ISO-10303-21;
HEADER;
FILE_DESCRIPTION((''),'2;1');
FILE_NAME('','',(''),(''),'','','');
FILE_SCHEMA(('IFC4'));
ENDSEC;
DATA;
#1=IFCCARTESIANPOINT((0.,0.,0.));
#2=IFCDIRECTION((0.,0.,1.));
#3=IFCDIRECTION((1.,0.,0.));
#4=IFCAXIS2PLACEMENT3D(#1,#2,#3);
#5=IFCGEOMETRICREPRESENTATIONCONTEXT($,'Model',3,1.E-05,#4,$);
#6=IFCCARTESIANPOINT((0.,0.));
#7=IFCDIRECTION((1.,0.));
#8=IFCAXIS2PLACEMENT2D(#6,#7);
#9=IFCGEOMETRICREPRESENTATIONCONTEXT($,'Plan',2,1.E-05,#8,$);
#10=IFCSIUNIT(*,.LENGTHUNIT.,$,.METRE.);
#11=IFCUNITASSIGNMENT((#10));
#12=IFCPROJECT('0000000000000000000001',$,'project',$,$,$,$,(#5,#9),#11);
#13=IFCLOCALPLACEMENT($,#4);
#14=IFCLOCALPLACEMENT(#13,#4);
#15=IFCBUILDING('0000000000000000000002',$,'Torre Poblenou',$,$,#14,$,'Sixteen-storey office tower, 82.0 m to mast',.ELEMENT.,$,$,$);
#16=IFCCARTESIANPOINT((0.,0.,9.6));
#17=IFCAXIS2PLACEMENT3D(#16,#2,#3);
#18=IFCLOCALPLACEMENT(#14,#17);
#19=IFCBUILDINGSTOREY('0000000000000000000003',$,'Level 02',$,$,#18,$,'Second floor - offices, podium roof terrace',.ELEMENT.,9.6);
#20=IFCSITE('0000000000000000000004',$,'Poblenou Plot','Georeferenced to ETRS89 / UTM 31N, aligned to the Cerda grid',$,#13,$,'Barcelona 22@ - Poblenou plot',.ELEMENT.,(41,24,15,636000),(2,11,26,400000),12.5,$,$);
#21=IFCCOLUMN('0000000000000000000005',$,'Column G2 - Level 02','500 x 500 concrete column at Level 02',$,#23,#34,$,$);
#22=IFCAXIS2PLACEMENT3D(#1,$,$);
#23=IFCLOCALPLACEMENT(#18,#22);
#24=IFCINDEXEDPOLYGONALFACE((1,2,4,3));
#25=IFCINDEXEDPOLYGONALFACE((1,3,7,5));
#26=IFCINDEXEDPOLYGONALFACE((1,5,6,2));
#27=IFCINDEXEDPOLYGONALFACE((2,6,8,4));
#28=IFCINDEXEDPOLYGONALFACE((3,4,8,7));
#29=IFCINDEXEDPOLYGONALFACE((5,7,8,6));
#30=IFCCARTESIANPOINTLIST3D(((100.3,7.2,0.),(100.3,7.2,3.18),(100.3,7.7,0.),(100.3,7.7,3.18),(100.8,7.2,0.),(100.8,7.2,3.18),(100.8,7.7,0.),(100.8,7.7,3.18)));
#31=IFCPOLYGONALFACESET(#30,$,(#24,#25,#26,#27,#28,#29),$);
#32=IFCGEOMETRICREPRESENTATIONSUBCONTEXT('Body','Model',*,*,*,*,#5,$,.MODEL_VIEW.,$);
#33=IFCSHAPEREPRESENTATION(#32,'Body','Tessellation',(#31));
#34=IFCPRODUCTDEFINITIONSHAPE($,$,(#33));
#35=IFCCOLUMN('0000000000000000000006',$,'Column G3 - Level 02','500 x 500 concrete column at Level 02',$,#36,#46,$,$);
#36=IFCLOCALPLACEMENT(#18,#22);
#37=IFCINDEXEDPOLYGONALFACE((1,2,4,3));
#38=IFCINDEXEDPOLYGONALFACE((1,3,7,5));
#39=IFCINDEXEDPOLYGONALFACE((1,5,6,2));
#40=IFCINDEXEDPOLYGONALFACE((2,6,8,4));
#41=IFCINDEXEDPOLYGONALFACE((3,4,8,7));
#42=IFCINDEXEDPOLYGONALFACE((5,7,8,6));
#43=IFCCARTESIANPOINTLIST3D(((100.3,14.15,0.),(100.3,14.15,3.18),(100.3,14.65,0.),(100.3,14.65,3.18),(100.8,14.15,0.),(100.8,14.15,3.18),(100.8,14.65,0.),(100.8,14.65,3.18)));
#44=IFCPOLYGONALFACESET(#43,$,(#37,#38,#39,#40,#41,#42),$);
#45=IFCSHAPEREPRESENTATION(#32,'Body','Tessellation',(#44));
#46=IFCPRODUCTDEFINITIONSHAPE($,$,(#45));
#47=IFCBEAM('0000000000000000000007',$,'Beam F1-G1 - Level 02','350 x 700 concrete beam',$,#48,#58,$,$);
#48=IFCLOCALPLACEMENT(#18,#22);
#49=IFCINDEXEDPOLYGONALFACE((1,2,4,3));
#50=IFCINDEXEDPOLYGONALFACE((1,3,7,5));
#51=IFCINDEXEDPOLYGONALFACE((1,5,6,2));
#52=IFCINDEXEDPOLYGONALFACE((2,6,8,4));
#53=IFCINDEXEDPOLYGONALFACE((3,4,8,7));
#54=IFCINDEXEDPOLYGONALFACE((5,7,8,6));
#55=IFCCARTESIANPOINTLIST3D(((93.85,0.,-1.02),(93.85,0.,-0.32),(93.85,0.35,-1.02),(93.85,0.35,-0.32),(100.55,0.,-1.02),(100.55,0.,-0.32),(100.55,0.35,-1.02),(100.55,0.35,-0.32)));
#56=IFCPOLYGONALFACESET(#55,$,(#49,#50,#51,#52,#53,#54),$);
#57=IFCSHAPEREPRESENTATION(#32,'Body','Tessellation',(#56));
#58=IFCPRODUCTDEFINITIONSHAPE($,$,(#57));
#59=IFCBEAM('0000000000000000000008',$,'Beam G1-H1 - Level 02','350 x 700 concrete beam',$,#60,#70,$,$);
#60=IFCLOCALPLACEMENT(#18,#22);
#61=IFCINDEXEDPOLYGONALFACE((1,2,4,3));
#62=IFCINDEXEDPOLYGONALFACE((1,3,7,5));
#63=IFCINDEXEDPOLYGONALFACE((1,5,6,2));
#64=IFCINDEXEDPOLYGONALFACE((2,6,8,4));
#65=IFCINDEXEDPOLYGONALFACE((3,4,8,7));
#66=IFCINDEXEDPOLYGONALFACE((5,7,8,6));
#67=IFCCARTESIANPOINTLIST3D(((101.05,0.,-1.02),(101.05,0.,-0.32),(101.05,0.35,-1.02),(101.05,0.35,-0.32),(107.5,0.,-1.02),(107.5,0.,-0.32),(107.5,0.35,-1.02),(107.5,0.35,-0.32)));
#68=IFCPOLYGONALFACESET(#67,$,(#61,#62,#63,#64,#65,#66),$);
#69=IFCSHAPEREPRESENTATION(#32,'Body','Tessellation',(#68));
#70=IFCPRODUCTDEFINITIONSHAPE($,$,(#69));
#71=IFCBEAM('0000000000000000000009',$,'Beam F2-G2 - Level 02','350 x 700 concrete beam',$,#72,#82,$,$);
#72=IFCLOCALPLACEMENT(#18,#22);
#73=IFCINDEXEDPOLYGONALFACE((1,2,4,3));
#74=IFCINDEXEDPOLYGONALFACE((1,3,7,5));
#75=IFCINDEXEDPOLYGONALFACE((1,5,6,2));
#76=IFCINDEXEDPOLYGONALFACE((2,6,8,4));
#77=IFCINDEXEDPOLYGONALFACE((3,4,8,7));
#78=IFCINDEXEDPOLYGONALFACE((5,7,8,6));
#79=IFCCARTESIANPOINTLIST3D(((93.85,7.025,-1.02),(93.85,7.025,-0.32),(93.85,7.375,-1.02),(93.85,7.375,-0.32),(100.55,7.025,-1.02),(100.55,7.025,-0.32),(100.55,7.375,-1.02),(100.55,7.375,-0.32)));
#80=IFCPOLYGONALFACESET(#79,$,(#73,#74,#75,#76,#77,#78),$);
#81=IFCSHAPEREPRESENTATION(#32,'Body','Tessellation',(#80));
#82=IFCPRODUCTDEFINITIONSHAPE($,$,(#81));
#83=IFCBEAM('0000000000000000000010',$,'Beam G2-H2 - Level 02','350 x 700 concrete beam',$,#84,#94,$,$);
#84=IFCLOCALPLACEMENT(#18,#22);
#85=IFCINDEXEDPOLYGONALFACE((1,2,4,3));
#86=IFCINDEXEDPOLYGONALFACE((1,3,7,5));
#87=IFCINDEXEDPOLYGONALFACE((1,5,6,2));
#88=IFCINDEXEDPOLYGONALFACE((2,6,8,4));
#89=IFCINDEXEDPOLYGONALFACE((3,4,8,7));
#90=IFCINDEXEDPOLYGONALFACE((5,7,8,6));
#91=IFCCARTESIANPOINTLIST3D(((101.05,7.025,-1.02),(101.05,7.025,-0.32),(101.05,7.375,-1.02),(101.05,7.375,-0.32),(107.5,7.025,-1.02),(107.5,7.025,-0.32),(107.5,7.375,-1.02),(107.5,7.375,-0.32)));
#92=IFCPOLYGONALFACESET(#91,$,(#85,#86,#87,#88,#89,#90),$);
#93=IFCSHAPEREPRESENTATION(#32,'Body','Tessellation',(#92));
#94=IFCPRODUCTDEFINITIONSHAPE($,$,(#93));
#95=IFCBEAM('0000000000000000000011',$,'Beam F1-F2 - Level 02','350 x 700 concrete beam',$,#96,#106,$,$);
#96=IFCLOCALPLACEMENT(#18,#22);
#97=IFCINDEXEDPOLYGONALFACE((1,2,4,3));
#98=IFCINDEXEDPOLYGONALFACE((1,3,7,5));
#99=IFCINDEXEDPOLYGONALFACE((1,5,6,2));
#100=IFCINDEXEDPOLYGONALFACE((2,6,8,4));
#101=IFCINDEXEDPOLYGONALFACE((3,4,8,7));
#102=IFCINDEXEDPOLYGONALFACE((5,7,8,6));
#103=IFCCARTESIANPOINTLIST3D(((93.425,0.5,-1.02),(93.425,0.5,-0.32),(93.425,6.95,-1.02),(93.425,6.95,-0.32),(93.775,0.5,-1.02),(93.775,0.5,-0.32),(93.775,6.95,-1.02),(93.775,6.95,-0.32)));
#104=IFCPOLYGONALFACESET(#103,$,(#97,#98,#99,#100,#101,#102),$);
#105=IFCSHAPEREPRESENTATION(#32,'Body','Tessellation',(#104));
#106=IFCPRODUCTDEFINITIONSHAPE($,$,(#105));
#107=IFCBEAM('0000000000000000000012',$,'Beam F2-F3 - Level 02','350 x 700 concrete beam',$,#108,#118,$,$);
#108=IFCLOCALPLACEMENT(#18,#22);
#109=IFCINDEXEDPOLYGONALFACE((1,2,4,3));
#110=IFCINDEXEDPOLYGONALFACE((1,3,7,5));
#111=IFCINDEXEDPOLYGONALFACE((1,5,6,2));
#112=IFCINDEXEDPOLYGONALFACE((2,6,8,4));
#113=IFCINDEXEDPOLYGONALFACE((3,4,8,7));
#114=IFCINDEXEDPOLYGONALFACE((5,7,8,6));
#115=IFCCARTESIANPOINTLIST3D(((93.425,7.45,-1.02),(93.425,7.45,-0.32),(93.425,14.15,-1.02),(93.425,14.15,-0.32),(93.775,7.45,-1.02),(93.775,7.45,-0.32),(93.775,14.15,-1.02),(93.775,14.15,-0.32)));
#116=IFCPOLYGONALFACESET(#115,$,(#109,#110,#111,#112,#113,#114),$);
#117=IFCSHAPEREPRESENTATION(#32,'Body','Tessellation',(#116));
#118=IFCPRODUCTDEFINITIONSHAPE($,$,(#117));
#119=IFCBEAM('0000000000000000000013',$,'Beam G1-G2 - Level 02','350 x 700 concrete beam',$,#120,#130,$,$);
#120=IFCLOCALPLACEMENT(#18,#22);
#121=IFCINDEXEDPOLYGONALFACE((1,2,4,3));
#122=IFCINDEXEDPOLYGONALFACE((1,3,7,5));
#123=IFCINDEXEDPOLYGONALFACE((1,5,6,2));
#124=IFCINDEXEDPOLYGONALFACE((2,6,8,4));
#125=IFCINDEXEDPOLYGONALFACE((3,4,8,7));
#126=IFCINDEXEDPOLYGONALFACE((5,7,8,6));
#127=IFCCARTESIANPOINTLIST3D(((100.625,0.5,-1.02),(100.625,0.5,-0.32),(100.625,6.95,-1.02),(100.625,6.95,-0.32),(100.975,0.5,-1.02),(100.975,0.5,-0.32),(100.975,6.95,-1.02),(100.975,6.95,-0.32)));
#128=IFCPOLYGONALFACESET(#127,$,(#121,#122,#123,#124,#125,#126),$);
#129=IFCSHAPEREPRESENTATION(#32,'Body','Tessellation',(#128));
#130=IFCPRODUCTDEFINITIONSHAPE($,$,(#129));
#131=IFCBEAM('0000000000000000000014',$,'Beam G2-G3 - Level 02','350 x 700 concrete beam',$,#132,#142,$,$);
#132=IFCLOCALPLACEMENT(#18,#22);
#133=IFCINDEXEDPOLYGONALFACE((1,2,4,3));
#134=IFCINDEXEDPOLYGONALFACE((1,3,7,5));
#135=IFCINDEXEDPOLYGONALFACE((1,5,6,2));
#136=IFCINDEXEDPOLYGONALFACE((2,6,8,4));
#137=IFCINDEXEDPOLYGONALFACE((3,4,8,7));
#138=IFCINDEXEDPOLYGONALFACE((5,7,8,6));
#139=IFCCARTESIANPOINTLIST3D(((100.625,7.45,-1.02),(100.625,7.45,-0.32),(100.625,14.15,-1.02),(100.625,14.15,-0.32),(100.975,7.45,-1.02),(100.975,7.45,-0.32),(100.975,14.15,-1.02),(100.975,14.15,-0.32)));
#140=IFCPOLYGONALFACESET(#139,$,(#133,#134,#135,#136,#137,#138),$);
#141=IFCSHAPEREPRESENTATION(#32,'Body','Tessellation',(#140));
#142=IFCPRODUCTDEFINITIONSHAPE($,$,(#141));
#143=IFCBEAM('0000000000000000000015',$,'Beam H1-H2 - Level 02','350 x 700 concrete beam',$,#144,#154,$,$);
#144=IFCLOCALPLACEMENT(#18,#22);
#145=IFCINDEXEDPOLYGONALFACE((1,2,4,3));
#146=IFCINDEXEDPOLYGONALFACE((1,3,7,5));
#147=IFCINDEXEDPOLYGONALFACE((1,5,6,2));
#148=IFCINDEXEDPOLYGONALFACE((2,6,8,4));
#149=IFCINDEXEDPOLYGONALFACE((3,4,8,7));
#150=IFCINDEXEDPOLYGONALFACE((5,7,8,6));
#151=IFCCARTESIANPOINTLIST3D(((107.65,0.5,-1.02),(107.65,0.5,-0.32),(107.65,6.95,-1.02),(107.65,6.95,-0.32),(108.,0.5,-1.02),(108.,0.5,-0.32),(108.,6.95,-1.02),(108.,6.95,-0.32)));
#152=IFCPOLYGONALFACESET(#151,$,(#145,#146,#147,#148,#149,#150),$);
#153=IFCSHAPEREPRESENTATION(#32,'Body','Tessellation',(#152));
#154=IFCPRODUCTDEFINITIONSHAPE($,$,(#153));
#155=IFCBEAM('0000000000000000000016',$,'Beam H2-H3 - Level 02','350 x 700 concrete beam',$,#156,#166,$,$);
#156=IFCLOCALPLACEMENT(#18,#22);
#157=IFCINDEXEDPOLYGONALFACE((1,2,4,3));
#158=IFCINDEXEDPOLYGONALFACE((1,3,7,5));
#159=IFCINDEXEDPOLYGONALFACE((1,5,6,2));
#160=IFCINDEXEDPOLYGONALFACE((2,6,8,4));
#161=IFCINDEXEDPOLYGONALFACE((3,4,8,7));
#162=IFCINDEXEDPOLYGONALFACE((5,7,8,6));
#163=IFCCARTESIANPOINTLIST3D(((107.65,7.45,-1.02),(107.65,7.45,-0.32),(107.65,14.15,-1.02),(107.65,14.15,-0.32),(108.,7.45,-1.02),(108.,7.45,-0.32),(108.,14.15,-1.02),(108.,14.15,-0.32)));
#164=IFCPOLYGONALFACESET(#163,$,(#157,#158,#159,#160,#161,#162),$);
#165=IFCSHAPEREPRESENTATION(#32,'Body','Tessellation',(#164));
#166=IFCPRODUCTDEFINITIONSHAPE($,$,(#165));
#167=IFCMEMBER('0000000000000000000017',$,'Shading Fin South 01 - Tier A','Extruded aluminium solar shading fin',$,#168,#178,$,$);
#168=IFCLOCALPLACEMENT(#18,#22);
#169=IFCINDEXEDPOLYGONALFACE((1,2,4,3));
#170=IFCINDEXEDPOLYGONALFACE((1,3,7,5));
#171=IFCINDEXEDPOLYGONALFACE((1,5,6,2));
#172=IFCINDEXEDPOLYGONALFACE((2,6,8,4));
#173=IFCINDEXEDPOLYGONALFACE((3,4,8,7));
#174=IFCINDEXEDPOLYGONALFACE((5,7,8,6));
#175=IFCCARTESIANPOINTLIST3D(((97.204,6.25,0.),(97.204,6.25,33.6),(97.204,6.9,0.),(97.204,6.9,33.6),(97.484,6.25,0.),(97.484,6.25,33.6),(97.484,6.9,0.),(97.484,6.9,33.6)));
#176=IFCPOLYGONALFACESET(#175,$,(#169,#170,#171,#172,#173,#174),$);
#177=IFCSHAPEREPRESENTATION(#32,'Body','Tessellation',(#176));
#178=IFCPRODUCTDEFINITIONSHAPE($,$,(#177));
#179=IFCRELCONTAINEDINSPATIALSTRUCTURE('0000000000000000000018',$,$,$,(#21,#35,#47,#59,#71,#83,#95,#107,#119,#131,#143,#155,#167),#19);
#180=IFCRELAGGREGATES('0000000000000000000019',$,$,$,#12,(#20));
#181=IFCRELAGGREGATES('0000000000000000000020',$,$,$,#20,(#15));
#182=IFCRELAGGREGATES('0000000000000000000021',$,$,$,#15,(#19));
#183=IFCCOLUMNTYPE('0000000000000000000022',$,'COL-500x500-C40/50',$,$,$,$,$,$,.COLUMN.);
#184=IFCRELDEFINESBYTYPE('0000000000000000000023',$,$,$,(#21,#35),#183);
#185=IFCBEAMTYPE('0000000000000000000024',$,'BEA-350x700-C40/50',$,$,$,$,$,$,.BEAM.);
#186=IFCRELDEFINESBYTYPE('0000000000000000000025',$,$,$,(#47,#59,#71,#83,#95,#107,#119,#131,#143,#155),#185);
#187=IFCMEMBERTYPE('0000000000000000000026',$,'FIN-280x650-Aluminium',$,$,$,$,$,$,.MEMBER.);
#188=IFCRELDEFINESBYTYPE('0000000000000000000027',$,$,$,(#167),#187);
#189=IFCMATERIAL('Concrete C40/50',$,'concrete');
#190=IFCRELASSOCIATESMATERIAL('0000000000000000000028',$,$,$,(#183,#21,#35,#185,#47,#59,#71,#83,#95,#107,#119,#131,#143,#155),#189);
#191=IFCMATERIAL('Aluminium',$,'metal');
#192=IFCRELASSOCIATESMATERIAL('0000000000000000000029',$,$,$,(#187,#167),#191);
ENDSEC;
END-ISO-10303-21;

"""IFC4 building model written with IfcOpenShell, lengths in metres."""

from ifc_helpers import new_model, si_unit, frame, origin_with_axes, origin_2d_with_axis, place, context, subcontext, project, spatial, line, indexed_curve, rectangle, outline, extrude, material, material_profile, profile_set, profile_usage, type_object, element, save


model = new_model("IFC4")

# Units and contexts
model_context = context("Model", 3, precision=1e-05, world=origin_with_axes())
plan_context = context("Plan", 2, precision=1e-05, world=origin_2d_with_axis())
body_context = subcontext(model_context, "Body", "Model", "MODEL_VIEW")
ifc_project = project(units=[si_unit("LENGTHUNIT", "METRE")], contexts=[model_context, plan_context])

# Site, building, storey
site_placement = place(None, origin_with_axes())
site = spatial("IfcSite", under=ifc_project, at=site_placement, Name="Poblenou Plot", Description="Georeferenced to ETRS89 / UTM 31N, aligned to the Cerda grid", LongName="Barcelona 22@ - Poblenou plot", CompositionType="ELEMENT", RefLatitude=(41, 24, 15, 636000), RefLongitude=(2, 11, 26, 400000), RefElevation=12.5)
building_placement = place(site_placement, origin_with_axes())
building = spatial("IfcBuilding", under=site, at=building_placement, Name="Torre Poblenou", LongName="Sixteen-storey office tower, 82.0 m to mast", CompositionType="ELEMENT")
storey_placement = place(building_placement, frame((0.0, 0.0, 9.6), z_axis=(0.0, 0.0, 1.0), x_axis=(1.0, 0.0, 0.0)))
storey = spatial("IfcBuildingStorey", under=building, at=storey_placement, Name="Level 02", LongName="Second floor - offices, podium roof terrace", CompositionType="ELEMENT", Elevation=9.6)

# Columns
ifc_material_1 = material(Name="Concrete C40/50", Category="concrete")
ifc_material_profile_1 = material_profile(ifc_material_1, rectangle(XDim=0.5, YDim=0.5))
ifc_profile_set_1 = profile_set([ifc_material_profile_1], Name="COL-500x500-C40/50")
ifc_profile_usage_1 = profile_usage(ifc_profile_set_1)
column_type = type_object("IfcColumnType", Name="COL-500x500-C40/50", PredefinedType="COLUMN", material=ifc_profile_set_1)
column_1_placement = place(storey_placement, frame((100.3, 7.2, 0.0), z_axis=(0.0, 0.0, 1.0), x_axis=(1.0, 0.0, 0.0)))
element("IfcColumn", 1, at=column_1_placement, inside=storey, type_object=column_type, material=ifc_profile_usage_1, Name="Column G2 - Level 02", Description="500 x 500 concrete column at Level 02", context=body_context, shape_type="SweptSolid", body=[
    extrude(outline(indexed_curve([(0.0, 0.0), (0.5, 0.0), (0.5, 0.5), (0.0, 0.5)], segments=[line(1, 2, 3, 4, 1)])), origin_with_axes(), (0.0, 0.0, 1.0), 3.18),
])
ifc_profile_usage_2 = profile_usage(ifc_profile_set_1)
column_2_placement = place(storey_placement, frame((100.3, 14.15, 0.0), z_axis=(0.0, 0.0, 1.0), x_axis=(1.0, 0.0, 0.0)))
element("IfcColumn", 2, at=column_2_placement, inside=storey, type_object=column_type, material=ifc_profile_usage_2, Name="Column G3 - Level 02", Description="500 x 500 concrete column at Level 02", context=body_context, shape_type="SweptSolid", body=[
    extrude(outline(indexed_curve([(0.0, 0.0), (0.5, 0.0), (0.5, 0.5), (0.0, 0.5)], segments=[line(1, 2, 3, 4, 1)])), origin_with_axes(), (0.0, 0.0, 1.0), 3.18),
])

# Beams
ifc_material_profile_2 = material_profile(ifc_material_1, rectangle(XDim=0.35, YDim=0.7))
ifc_profile_set_2 = profile_set([ifc_material_profile_2], Name="BEA-350x700-C40/50")
ifc_profile_usage_3 = profile_usage(ifc_profile_set_2)
beam_type = type_object("IfcBeamType", Name="BEA-350x700-C40/50", PredefinedType="BEAM", material=ifc_profile_set_2)
beam_1_placement = place(storey_placement, frame((93.85, 0.0, -1.02), z_axis=(0.0, 0.0, 1.0), x_axis=(1.0, 0.0, 0.0)))
element("IfcBeam", 3, at=beam_1_placement, inside=storey, type_object=beam_type, material=ifc_profile_usage_3, Name="Beam F1-G1 - Level 02", Description="350 x 700 concrete beam", context=body_context, shape_type="SweptSolid", body=[
    extrude(outline(indexed_curve([(0.0, 0.0), (6.7, 0.0), (6.7, 0.35), (0.0, 0.35)], segments=[line(1, 2, 3, 4, 1)])), origin_with_axes(), (0.0, 0.0, 1.0), 0.7),
])
ifc_profile_usage_4 = profile_usage(ifc_profile_set_2)
beam_2_placement = place(storey_placement, frame((101.05, 0.0, -1.02), z_axis=(0.0, 0.0, 1.0), x_axis=(1.0, 0.0, 0.0)))
element("IfcBeam", 4, at=beam_2_placement, inside=storey, type_object=beam_type, material=ifc_profile_usage_4, Name="Beam G1-H1 - Level 02", Description="350 x 700 concrete beam", context=body_context, shape_type="SweptSolid", body=[
    extrude(outline(indexed_curve([(0.0, 0.0), (6.45, 0.0), (6.45, 0.35), (0.0, 0.35)], segments=[line(1, 2, 3, 4, 1)])), origin_with_axes(), (0.0, 0.0, 1.0), 0.7),
])
ifc_profile_usage_5 = profile_usage(ifc_profile_set_2)
beam_3_placement = place(storey_placement, frame((93.85, 7.025, -1.02), z_axis=(0.0, 0.0, 1.0), x_axis=(1.0, 0.0, 0.0)))
element("IfcBeam", 5, at=beam_3_placement, inside=storey, type_object=beam_type, material=ifc_profile_usage_5, Name="Beam F2-G2 - Level 02", Description="350 x 700 concrete beam", context=body_context, shape_type="SweptSolid", body=[
    extrude(outline(indexed_curve([(0.0, 0.0), (6.7, 0.0), (6.7, 0.35), (0.0, 0.35)], segments=[line(1, 2, 3, 4, 1)])), origin_with_axes(), (0.0, 0.0, 1.0), 0.7),
])
ifc_profile_usage_6 = profile_usage(ifc_profile_set_2)
beam_4_placement = place(storey_placement, frame((101.05, 7.025, -1.02), z_axis=(0.0, 0.0, 1.0), x_axis=(1.0, 0.0, 0.0)))
element("IfcBeam", 6, at=beam_4_placement, inside=storey, type_object=beam_type, material=ifc_profile_usage_6, Name="Beam G2-H2 - Level 02", Description="350 x 700 concrete beam", context=body_context, shape_type="SweptSolid", body=[
    extrude(outline(indexed_curve([(0.0, 0.0), (6.45, 0.0), (6.45, 0.35), (0.0, 0.35)], segments=[line(1, 2, 3, 4, 1)])), origin_with_axes(), (0.0, 0.0, 1.0), 0.7),
])
ifc_profile_usage_7 = profile_usage(ifc_profile_set_2)
beam_5_placement = place(storey_placement, frame((93.775, 0.5, -1.02), z_axis=(0.0, 0.0, 1.0), x_axis=(0.0, 1.0, 0.0)))
element("IfcBeam", 7, at=beam_5_placement, inside=storey, type_object=beam_type, material=ifc_profile_usage_7, Name="Beam F1-F2 - Level 02", Description="350 x 700 concrete beam", context=body_context, shape_type="SweptSolid", body=[
    extrude(outline(indexed_curve([(0.0, 0.0), (6.45, 0.0), (6.45, 0.35), (0.0, 0.35)], segments=[line(1, 2, 3, 4, 1)])), origin_with_axes(), (0.0, 0.0, 1.0), 0.7),
])
ifc_profile_usage_8 = profile_usage(ifc_profile_set_2)
beam_6_placement = place(storey_placement, frame((93.775, 7.45, -1.02), z_axis=(0.0, 0.0, 1.0), x_axis=(0.0, 1.0, 0.0)))
element("IfcBeam", 8, at=beam_6_placement, inside=storey, type_object=beam_type, material=ifc_profile_usage_8, Name="Beam F2-F3 - Level 02", Description="350 x 700 concrete beam", context=body_context, shape_type="SweptSolid", body=[
    extrude(outline(indexed_curve([(0.0, 0.0), (6.7, 0.0), (6.7, 0.35), (0.0, 0.35)], segments=[line(1, 2, 3, 4, 1)])), origin_with_axes(), (0.0, 0.0, 1.0), 0.7),
])
ifc_profile_usage_9 = profile_usage(ifc_profile_set_2)
beam_7_placement = place(storey_placement, frame((100.975, 0.5, -1.02), z_axis=(0.0, 0.0, 1.0), x_axis=(0.0, 1.0, 0.0)))
element("IfcBeam", 9, at=beam_7_placement, inside=storey, type_object=beam_type, material=ifc_profile_usage_9, Name="Beam G1-G2 - Level 02", Description="350 x 700 concrete beam", context=body_context, shape_type="SweptSolid", body=[
    extrude(outline(indexed_curve([(0.0, 0.0), (6.45, 0.0), (6.45, 0.35), (0.0, 0.35)], segments=[line(1, 2, 3, 4, 1)])), origin_with_axes(), (0.0, 0.0, 1.0), 0.7),
])
ifc_profile_usage_10 = profile_usage(ifc_profile_set_2)
beam_8_placement = place(storey_placement, frame((100.975, 7.45, -1.02), z_axis=(0.0, 0.0, 1.0), x_axis=(0.0, 1.0, 0.0)))
element("IfcBeam", 10, at=beam_8_placement, inside=storey, type_object=beam_type, material=ifc_profile_usage_10, Name="Beam G2-G3 - Level 02", Description="350 x 700 concrete beam", context=body_context, shape_type="SweptSolid", body=[
    extrude(outline(indexed_curve([(0.0, 0.0), (6.7, 0.0), (6.7, 0.35), (0.0, 0.35)], segments=[line(1, 2, 3, 4, 1)])), origin_with_axes(), (0.0, 0.0, 1.0), 0.7),
])
ifc_profile_usage_11 = profile_usage(ifc_profile_set_2)
beam_9_placement = place(storey_placement, frame((108.0, 0.5, -1.02), z_axis=(0.0, 0.0, 1.0), x_axis=(0.0, 1.0, 0.0)))
element("IfcBeam", 11, at=beam_9_placement, inside=storey, type_object=beam_type, material=ifc_profile_usage_11, Name="Beam H1-H2 - Level 02", Description="350 x 700 concrete beam", context=body_context, shape_type="SweptSolid", body=[
    extrude(outline(indexed_curve([(0.0, 0.0), (6.45, 0.0), (6.45, 0.35), (0.0, 0.35)], segments=[line(1, 2, 3, 4, 1)])), origin_with_axes(), (0.0, 0.0, 1.0), 0.7),
])
ifc_profile_usage_12 = profile_usage(ifc_profile_set_2)
beam_10_placement = place(storey_placement, frame((108.0, 7.45, -1.02), z_axis=(0.0, 0.0, 1.0), x_axis=(0.0, 1.0, 0.0)))
element("IfcBeam", 12, at=beam_10_placement, inside=storey, type_object=beam_type, material=ifc_profile_usage_12, Name="Beam H2-H3 - Level 02", Description="350 x 700 concrete beam", context=body_context, shape_type="SweptSolid", body=[
    extrude(outline(indexed_curve([(0.0, 0.0), (6.7, 0.0), (6.7, 0.35), (0.0, 0.35)], segments=[line(1, 2, 3, 4, 1)])), origin_with_axes(), (0.0, 0.0, 1.0), 0.7),
])

# Member
ifc_material_2 = material(Name="Aluminium", Category="metal")
ifc_material_profile_3 = material_profile(ifc_material_2, rectangle(XDim=0.28, YDim=0.65))
ifc_profile_set_3 = profile_set([ifc_material_profile_3], Name="FIN-280x650-Aluminium")
ifc_profile_usage_13 = profile_usage(ifc_profile_set_3)
member_type = type_object("IfcMemberType", Name="FIN-280x650-Aluminium", PredefinedType="MEMBER", material=ifc_profile_set_3)
member_1_placement = place(storey_placement, frame((97.484, 6.9, 0.0), z_axis=(0.0, 0.0, 1.0), x_axis=(-1.0, 0.0, 0.0)))
element("IfcMember", 13, at=member_1_placement, inside=storey, type_object=member_type, material=ifc_profile_usage_13, Name="Shading Fin South 01 - Tier A", Description="Extruded aluminium solar shading fin", context=body_context, shape_type="SweptSolid", body=[
    extrude(outline(indexed_curve([(0.0, 0.0), (0.28, 0.0), (0.28, 0.65), (0.0, 0.65)], segments=[line(1, 2, 3, 4, 1)])), origin_with_axes(), (0.0, 0.0, 1.0), 33.6),
])

save(model, "model.ifc")
